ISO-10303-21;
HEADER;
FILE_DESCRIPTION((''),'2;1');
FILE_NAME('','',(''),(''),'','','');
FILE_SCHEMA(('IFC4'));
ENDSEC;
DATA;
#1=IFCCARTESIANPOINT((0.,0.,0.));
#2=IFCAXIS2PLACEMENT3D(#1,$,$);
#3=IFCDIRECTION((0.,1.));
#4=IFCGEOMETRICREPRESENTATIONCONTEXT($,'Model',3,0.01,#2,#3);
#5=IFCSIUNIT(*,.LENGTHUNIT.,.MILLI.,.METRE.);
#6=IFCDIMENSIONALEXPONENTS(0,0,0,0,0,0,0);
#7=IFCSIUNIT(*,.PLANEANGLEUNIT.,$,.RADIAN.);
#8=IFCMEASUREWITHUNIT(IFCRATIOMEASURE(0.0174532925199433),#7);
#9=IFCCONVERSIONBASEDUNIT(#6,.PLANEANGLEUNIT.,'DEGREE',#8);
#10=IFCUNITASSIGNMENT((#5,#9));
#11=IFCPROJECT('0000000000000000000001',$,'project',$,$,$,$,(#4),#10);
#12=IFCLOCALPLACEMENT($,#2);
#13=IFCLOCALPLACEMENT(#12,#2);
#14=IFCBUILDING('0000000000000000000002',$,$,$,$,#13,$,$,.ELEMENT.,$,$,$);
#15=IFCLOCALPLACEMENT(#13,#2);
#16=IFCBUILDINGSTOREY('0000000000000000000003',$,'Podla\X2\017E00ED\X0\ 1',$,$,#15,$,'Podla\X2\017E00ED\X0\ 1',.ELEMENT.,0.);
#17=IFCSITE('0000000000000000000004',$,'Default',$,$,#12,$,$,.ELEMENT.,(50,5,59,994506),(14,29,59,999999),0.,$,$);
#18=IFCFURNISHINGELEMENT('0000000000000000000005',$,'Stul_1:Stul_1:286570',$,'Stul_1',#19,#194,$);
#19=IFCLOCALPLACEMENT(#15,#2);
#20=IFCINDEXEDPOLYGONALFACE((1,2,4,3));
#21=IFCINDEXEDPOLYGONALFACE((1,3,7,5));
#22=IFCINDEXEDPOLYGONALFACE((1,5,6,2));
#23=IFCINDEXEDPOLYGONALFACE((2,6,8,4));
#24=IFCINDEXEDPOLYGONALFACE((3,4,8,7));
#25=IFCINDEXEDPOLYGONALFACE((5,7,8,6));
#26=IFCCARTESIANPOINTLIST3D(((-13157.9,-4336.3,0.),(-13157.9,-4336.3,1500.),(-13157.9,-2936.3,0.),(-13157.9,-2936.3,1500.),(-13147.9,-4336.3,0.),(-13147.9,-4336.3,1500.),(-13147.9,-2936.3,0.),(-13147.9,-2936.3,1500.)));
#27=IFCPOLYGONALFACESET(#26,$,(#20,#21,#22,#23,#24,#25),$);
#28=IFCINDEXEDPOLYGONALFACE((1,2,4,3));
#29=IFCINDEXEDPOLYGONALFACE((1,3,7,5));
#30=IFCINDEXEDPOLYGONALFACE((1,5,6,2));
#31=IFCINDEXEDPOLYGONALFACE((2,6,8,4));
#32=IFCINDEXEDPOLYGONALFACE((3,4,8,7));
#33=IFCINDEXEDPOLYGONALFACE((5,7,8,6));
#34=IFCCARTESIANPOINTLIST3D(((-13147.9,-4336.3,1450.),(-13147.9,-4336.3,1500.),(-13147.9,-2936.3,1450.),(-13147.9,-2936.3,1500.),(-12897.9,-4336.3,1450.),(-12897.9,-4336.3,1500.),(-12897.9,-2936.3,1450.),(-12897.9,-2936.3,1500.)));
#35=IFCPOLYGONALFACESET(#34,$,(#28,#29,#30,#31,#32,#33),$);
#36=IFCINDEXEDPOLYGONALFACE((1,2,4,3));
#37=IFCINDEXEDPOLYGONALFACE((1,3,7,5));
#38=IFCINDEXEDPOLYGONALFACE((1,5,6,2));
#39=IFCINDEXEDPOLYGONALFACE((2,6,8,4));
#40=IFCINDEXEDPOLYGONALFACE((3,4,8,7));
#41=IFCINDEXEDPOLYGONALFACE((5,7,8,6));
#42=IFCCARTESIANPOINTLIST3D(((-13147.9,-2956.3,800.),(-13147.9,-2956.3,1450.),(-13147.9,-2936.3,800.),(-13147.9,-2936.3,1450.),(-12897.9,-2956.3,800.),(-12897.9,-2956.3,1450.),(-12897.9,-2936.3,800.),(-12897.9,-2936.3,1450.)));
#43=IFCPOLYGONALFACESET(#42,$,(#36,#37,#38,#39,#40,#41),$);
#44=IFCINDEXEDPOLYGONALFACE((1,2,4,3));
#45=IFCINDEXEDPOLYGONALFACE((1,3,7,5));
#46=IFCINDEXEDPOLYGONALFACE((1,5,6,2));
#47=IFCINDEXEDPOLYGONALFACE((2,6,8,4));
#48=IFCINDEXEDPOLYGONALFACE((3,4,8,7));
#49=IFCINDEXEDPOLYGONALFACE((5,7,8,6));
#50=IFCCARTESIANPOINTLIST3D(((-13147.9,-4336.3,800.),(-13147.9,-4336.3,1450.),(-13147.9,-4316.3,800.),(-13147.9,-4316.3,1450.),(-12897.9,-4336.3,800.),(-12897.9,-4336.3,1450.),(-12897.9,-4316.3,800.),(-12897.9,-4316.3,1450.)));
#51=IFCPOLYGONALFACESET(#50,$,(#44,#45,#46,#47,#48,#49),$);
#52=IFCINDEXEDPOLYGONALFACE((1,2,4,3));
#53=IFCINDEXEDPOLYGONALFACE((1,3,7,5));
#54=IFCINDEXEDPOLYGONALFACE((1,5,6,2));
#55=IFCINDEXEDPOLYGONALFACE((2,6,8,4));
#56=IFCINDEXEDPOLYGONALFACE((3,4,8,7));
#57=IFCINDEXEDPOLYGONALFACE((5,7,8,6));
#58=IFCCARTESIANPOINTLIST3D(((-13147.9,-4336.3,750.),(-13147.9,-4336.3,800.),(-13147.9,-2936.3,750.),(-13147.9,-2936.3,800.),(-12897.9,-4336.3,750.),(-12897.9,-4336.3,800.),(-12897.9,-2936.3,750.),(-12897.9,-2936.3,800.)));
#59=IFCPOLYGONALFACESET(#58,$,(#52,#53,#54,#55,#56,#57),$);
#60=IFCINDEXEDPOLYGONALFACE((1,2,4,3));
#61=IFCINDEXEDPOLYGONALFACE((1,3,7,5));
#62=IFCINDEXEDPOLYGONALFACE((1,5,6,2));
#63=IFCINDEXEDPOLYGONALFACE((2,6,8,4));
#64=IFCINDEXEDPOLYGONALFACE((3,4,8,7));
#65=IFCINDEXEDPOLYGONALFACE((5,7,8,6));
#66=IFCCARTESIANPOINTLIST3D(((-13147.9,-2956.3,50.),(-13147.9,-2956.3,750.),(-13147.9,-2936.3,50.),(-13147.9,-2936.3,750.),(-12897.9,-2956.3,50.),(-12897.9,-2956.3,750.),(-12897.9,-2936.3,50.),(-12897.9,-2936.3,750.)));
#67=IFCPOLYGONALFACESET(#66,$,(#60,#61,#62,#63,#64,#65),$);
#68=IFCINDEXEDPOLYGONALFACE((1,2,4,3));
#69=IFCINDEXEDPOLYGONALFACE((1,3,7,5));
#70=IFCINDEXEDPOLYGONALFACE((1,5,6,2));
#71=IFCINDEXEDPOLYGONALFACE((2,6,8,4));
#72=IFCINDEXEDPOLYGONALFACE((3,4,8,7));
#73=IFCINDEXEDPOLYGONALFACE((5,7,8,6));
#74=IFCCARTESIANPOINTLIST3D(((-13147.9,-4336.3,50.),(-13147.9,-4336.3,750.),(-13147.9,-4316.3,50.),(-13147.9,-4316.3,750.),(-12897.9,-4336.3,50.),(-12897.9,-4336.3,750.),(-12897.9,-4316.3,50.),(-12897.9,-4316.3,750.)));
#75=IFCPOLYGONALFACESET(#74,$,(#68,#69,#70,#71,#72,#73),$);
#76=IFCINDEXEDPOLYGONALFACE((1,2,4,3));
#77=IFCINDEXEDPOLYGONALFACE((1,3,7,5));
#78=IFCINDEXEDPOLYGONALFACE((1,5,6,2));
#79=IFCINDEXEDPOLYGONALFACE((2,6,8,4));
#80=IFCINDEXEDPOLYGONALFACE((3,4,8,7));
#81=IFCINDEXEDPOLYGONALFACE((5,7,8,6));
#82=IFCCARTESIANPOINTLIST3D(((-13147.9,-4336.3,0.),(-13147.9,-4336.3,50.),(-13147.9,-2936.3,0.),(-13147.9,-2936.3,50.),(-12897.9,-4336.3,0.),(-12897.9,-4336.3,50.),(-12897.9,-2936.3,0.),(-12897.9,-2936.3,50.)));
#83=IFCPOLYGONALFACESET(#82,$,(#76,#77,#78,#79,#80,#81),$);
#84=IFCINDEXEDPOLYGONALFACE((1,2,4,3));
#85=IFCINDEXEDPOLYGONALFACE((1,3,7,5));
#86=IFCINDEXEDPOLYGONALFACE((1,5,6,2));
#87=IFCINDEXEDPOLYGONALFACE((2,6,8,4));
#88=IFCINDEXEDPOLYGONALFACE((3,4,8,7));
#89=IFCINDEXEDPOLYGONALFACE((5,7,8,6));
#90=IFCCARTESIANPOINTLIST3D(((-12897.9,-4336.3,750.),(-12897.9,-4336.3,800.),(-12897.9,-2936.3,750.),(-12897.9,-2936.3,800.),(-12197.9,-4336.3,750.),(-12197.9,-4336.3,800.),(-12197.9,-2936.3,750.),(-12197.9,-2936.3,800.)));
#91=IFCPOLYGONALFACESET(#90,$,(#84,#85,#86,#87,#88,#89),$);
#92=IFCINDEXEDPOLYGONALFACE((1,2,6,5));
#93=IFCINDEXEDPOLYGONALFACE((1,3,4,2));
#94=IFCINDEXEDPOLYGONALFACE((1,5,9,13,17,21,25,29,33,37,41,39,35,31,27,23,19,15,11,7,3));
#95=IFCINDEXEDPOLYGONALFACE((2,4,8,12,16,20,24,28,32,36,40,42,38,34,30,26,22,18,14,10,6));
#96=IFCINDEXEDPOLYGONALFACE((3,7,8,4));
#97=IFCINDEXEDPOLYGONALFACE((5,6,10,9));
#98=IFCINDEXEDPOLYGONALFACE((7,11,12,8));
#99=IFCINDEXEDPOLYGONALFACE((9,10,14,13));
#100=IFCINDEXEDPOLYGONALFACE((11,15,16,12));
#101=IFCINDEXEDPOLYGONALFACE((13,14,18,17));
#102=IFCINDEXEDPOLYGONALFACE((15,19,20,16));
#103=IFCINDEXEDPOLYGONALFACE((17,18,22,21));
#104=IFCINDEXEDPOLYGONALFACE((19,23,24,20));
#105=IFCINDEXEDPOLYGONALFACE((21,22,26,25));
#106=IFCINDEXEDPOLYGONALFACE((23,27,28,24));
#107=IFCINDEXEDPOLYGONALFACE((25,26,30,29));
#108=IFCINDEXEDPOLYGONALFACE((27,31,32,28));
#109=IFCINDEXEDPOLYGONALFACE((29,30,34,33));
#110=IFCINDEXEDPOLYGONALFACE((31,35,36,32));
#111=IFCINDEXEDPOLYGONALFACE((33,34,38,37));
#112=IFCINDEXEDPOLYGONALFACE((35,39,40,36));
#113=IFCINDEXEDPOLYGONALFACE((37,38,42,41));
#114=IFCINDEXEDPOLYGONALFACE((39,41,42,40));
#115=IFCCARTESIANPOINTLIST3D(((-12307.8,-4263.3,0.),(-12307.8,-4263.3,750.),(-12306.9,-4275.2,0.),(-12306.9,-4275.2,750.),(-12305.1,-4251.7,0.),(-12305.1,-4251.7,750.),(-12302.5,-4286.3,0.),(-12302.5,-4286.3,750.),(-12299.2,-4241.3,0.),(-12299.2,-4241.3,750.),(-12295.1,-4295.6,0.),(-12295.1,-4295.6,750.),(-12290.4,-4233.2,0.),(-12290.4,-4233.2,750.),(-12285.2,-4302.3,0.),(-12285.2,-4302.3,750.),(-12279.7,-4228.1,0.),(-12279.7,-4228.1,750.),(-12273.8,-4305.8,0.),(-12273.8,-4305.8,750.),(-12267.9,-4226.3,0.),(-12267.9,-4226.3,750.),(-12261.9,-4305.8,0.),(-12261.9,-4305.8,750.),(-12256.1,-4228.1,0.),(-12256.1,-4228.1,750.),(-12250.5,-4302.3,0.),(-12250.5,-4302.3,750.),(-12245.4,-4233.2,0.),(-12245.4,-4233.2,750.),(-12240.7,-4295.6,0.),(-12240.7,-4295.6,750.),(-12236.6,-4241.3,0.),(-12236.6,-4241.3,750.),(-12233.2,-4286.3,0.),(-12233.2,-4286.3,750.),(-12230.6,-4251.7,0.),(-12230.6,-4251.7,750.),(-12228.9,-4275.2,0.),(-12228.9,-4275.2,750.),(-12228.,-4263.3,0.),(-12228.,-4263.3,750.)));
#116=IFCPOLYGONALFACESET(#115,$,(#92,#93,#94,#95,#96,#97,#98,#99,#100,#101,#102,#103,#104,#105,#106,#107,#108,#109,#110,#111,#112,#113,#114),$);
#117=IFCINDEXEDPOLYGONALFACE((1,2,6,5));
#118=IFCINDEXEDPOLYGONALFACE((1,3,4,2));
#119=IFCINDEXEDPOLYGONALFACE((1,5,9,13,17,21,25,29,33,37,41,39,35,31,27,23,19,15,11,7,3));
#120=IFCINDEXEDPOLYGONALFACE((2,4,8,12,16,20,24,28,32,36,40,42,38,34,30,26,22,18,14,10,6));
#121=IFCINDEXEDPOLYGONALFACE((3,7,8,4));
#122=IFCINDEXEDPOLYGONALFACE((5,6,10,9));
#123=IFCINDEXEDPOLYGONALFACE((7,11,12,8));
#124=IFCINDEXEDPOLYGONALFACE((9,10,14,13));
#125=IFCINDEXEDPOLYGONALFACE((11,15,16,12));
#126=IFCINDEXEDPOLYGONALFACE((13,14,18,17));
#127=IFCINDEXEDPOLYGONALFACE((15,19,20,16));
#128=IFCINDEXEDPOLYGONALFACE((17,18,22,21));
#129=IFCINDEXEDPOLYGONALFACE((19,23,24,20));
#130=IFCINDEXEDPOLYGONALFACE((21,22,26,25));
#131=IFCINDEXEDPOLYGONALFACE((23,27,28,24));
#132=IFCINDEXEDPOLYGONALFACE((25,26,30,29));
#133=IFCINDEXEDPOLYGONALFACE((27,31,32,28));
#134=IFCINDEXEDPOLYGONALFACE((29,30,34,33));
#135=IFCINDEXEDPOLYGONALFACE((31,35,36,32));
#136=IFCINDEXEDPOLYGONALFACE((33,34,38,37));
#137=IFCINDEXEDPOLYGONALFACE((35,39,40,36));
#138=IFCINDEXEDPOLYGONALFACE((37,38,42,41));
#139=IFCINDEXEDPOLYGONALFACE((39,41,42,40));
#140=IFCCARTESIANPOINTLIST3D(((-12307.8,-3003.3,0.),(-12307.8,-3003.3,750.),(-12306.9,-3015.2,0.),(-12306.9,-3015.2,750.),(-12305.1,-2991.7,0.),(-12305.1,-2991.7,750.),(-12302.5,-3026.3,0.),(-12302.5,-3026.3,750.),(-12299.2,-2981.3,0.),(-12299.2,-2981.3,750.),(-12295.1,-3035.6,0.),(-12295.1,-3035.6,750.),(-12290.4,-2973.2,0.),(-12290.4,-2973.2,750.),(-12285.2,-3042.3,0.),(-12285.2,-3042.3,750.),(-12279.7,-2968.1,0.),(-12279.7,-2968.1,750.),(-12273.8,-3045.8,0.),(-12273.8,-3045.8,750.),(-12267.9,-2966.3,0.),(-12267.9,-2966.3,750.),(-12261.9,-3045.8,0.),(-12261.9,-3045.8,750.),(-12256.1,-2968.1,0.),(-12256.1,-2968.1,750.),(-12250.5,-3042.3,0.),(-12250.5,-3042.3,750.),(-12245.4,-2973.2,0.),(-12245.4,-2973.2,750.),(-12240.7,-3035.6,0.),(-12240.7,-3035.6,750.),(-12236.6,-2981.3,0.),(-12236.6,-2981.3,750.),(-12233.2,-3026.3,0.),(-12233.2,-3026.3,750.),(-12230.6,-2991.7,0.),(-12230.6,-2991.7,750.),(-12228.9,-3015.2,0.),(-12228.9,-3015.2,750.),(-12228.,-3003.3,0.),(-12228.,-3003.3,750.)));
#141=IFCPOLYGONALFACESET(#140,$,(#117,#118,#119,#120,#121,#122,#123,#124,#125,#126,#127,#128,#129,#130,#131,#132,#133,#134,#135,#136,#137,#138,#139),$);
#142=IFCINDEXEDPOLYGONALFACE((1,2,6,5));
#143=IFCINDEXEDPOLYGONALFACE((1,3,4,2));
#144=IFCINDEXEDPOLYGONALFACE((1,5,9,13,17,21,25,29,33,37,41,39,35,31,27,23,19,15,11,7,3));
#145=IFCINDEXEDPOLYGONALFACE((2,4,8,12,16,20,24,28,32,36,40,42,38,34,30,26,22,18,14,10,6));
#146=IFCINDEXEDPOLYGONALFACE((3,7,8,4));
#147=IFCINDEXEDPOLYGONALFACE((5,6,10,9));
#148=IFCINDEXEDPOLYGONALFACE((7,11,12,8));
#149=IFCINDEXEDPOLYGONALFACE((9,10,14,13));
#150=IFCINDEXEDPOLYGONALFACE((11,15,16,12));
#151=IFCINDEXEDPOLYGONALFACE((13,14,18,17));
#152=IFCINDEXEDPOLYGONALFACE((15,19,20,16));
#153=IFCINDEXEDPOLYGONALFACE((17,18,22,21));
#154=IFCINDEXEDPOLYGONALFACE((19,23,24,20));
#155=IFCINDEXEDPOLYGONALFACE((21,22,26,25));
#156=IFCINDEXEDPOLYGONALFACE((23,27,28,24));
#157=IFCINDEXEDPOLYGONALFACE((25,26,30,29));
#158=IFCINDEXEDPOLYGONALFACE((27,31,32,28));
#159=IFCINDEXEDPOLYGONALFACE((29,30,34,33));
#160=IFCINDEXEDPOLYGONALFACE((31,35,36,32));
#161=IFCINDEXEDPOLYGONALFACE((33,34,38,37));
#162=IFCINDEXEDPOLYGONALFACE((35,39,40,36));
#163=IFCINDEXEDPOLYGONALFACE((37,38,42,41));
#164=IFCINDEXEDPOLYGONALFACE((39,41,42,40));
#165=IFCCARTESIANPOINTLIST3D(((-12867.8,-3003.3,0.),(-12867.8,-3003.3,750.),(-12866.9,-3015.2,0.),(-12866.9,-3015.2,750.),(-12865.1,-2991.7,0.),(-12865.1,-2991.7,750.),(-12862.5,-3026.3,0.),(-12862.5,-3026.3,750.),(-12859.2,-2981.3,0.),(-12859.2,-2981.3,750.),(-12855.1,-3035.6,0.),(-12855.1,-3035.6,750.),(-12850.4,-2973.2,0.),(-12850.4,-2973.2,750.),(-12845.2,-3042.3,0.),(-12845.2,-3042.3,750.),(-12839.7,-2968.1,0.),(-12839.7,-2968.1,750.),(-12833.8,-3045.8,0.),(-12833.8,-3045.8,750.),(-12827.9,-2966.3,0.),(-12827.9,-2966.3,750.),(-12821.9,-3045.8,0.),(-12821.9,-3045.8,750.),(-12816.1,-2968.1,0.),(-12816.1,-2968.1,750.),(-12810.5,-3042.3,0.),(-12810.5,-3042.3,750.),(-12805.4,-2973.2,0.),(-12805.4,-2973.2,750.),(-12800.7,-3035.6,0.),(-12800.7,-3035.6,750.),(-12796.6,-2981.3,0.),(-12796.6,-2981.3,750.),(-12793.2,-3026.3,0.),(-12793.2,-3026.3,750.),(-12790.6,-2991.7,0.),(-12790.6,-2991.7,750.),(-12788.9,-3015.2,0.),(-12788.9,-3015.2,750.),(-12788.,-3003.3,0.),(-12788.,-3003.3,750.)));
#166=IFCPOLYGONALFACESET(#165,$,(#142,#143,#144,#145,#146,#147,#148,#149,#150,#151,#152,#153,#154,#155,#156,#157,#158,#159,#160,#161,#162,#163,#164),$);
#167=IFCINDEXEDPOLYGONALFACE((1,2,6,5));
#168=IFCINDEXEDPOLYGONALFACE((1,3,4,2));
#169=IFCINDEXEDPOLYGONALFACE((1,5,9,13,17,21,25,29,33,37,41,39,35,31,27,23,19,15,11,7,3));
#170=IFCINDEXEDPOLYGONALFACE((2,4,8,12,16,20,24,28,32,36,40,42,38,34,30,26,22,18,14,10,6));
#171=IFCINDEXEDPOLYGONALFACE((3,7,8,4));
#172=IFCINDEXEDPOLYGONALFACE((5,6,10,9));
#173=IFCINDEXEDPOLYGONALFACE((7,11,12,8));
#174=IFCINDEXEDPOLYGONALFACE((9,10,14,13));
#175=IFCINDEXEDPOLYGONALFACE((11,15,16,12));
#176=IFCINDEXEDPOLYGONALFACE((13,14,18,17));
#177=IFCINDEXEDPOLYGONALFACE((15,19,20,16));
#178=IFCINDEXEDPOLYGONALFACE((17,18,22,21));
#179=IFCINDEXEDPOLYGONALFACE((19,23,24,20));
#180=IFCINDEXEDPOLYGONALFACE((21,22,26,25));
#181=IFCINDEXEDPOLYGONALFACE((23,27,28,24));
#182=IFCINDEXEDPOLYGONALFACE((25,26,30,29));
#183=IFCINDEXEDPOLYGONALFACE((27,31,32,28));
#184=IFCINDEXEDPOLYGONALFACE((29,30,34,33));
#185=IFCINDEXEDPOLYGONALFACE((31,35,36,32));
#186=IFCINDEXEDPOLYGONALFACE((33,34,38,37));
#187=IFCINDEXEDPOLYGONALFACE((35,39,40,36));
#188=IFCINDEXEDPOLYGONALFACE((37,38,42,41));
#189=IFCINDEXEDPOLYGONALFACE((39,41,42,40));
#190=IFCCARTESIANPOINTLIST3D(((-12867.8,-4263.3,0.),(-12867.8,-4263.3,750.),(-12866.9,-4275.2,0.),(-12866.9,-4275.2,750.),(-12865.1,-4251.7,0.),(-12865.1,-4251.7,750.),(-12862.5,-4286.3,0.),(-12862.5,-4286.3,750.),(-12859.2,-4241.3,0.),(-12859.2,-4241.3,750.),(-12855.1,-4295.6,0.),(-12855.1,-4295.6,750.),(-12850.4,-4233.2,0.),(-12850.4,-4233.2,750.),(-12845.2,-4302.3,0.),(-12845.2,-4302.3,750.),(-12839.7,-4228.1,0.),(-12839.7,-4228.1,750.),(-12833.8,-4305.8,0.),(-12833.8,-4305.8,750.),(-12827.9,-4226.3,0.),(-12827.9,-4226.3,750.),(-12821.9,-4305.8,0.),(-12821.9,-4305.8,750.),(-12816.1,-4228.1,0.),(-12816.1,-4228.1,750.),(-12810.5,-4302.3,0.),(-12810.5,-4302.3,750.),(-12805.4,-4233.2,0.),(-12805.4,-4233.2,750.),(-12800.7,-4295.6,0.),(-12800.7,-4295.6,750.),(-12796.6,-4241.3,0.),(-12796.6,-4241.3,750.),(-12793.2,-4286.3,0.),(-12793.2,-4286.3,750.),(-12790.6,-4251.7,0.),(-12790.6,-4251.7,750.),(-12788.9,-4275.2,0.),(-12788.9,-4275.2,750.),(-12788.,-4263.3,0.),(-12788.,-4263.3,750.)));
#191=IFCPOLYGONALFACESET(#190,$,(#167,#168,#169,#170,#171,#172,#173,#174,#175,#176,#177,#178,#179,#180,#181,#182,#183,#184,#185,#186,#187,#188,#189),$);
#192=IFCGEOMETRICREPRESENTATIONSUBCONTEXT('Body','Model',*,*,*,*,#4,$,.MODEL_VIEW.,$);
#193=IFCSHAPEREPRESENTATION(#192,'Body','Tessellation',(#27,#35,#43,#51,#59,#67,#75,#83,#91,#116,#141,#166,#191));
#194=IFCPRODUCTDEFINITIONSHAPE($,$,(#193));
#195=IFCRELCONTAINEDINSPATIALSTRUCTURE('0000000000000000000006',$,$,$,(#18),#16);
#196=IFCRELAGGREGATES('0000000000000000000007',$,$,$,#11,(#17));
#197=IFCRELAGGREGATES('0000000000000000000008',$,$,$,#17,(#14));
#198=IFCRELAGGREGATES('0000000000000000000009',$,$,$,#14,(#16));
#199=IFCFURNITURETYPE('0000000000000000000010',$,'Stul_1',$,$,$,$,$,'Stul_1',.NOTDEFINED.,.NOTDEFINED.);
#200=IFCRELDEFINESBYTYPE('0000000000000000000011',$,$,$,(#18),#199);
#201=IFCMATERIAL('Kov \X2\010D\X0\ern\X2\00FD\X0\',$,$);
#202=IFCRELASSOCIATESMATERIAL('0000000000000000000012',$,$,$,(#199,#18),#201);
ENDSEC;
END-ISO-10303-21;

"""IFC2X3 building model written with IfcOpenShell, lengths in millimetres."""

from ifc_helpers import new_model, entity, si_unit, converted_unit, direction, frame, frame_2d, origin, origin_2d_with_axis, place, context, subcontext, project, spatial, rectangle, circle, extrude, source, transform, mapped, material, type_object, type_shapes, element, save


model = new_model("IFC2X3")

# Units and contexts
model_context = context("Model", 3, precision=0.01, world=origin(), true_north=direction((0.0, 1.0)))
body_context = subcontext(model_context, "Body", "Model", "MODEL_VIEW")
ifc_project = project(units=[si_unit("LENGTHUNIT", "METRE", prefix="MILLI"), converted_unit("PLANEANGLEUNIT", "DEGREE", entity("IfcRatioMeasure", 0.0174532925199433), si_unit("PLANEANGLEUNIT", "RADIAN"), dimensions=[0, 0, 0, 0, 0, 0, 0])], contexts=[model_context])

# Site, building, storey
site_placement = place(None, origin())
site = spatial("IfcSite", under=ifc_project, at=site_placement, Name="Default", CompositionType="ELEMENT", RefLatitude=(50, 5, 59, 994506), RefLongitude=(14, 29, 59, 999999), RefElevation=0.0)
building_placement = place(site_placement, origin())
building = spatial("IfcBuilding", under=site, at=building_placement, CompositionType="ELEMENT")
storey_placement = place(building_placement, origin())
storey = spatial("IfcBuildingStorey", under=building, at=storey_placement, Name="Podlaží 1", LongName="Podlaží 1", CompositionType="ELEMENT", Elevation=0.0)

# Furnishing element
ifc_material_1 = material(Name="Kov černý")
furniture_type = type_object("IfcFurnitureType", Name="Stul_1", ElementType="Stul_1", material=ifc_material_1)
shared_shape_1 = source(origin(), body_context, "Body", "SweptSolid", [
    extrude(rectangle(XDim=1400.0, YDim=10.0, at=origin_2d_with_axis()), frame((0.0, 605.0, 0.0), z_axis=(0.0, 0.0, 1.0), x_axis=(-1.0, 0.0, 0.0)), (0.0, 0.0, 1.0), 1500.0),
    extrude(rectangle(XDim=1400.0, YDim=250.0, at=frame_2d((0.0, 0.0), x_axis=(1.0, 0.0))), frame((0.0, 475.0, 1450.0), z_axis=(0.0, 0.0, 1.0), x_axis=(-1.0, 0.0, 0.0)), (0.0, 0.0, 1.0), 50.0),
    extrude(rectangle(XDim=20.0, YDim=250.0, at=origin_2d_with_axis()), frame((690.0, 475.0, 800.0), z_axis=(0.0, 0.0, 1.0), x_axis=(-1.0, 0.0, 0.0)), (0.0, 0.0, 1.0), 650.0),
    extrude(rectangle(XDim=20.0, YDim=250.0, at=frame_2d((0.0, 0.0), x_axis=(1.0, 0.0))), frame((-690.0, 475.0, 800.0), z_axis=(0.0, 0.0, 1.0), x_axis=(-1.0, 0.0, 0.0)), (0.0, 0.0, 1.0), 650.0),
    extrude(rectangle(XDim=1400.0, YDim=250.0, at=origin_2d_with_axis()), frame((0.0, 475.0, 750.0), z_axis=(0.0, 0.0, 1.0), x_axis=(-1.0, 0.0, 0.0)), (0.0, 0.0, 1.0), 50.0),
    extrude(rectangle(XDim=20.0, YDim=250.0, at=origin_2d_with_axis()), frame((690.0, 475.0, 50.0), z_axis=(0.0, 0.0, 1.0), x_axis=(-1.0, 0.0, 0.0)), (0.0, 0.0, 1.0), 700.0),
    extrude(rectangle(XDim=20.0, YDim=250.0, at=frame_2d((0.0, 0.0), x_axis=(1.0, 0.0))), frame((-690.0, 475.0, 50.0), z_axis=(0.0, 0.0, 1.0), x_axis=(-1.0, 0.0, 0.0)), (0.0, 0.0, 1.0), 700.0),
    extrude(rectangle(XDim=1400.0, YDim=250.0, at=origin_2d_with_axis()), frame((0.0, 475.0, 0.0), z_axis=(0.0, 0.0, 1.0), x_axis=(-1.0, 0.0, 0.0)), (0.0, 0.0, 1.0), 50.0),
    extrude(rectangle(XDim=1400.0, YDim=700.0, at=origin_2d_with_axis()), frame((0.0, 0.0, 750.0), z_axis=(0.0, 0.0, 1.0), x_axis=(-1.0, 0.0, 0.0)), (0.0, 0.0, 1.0), 50.0),
    extrude(circle(Radius=40.0, at=frame_2d((0.0, 0.0), x_axis=(1.0, 0.0))), frame((-630.0, -280.0, 0.0)), (0.0, 0.0, 1.0), 750.0),
    extrude(circle(Radius=40.0, at=frame_2d((0.0, 0.0), x_axis=(1.0, 0.0))), frame((630.0, -280.0, 0.0)), (0.0, 0.0, 1.0), 750.0),
    extrude(circle(Radius=40.0, at=frame_2d((0.0, 0.0), x_axis=(1.0, 0.0))), frame((630.0, 280.0, 0.0)), (0.0, 0.0, 1.0), 750.0),
    extrude(circle(Radius=40.0, at=frame_2d((0.0, 0.0), x_axis=(1.0, 0.0))), frame((-630.0, 280.0, 0.0)), (0.0, 0.0, 1.0), 750.0),
])
type_shapes(furniture_type, [shared_shape_1])
for number, where, z_axis, x_axis, name in (
    (1, (-12547.9, -3636.3, 0.0), (0.0, 0.0, 1.0), (0.0, 1.0, 0.0), "Stul_1:Stul_1:286570"),
):
    element("IfcFurnishingElement", number, at=place(storey_placement, frame(where, z_axis=z_axis, x_axis=x_axis)), inside=storey, type_object=furniture_type, material=ifc_material_1, Name=name, ObjectType="Stul_1", context=body_context, shape_type="MappedRepresentation", body=[
        mapped(shared_shape_1, transform((0.0, 0.0, 0.0), scale=1.0)),
    ])

save(model, "model.ifc")
